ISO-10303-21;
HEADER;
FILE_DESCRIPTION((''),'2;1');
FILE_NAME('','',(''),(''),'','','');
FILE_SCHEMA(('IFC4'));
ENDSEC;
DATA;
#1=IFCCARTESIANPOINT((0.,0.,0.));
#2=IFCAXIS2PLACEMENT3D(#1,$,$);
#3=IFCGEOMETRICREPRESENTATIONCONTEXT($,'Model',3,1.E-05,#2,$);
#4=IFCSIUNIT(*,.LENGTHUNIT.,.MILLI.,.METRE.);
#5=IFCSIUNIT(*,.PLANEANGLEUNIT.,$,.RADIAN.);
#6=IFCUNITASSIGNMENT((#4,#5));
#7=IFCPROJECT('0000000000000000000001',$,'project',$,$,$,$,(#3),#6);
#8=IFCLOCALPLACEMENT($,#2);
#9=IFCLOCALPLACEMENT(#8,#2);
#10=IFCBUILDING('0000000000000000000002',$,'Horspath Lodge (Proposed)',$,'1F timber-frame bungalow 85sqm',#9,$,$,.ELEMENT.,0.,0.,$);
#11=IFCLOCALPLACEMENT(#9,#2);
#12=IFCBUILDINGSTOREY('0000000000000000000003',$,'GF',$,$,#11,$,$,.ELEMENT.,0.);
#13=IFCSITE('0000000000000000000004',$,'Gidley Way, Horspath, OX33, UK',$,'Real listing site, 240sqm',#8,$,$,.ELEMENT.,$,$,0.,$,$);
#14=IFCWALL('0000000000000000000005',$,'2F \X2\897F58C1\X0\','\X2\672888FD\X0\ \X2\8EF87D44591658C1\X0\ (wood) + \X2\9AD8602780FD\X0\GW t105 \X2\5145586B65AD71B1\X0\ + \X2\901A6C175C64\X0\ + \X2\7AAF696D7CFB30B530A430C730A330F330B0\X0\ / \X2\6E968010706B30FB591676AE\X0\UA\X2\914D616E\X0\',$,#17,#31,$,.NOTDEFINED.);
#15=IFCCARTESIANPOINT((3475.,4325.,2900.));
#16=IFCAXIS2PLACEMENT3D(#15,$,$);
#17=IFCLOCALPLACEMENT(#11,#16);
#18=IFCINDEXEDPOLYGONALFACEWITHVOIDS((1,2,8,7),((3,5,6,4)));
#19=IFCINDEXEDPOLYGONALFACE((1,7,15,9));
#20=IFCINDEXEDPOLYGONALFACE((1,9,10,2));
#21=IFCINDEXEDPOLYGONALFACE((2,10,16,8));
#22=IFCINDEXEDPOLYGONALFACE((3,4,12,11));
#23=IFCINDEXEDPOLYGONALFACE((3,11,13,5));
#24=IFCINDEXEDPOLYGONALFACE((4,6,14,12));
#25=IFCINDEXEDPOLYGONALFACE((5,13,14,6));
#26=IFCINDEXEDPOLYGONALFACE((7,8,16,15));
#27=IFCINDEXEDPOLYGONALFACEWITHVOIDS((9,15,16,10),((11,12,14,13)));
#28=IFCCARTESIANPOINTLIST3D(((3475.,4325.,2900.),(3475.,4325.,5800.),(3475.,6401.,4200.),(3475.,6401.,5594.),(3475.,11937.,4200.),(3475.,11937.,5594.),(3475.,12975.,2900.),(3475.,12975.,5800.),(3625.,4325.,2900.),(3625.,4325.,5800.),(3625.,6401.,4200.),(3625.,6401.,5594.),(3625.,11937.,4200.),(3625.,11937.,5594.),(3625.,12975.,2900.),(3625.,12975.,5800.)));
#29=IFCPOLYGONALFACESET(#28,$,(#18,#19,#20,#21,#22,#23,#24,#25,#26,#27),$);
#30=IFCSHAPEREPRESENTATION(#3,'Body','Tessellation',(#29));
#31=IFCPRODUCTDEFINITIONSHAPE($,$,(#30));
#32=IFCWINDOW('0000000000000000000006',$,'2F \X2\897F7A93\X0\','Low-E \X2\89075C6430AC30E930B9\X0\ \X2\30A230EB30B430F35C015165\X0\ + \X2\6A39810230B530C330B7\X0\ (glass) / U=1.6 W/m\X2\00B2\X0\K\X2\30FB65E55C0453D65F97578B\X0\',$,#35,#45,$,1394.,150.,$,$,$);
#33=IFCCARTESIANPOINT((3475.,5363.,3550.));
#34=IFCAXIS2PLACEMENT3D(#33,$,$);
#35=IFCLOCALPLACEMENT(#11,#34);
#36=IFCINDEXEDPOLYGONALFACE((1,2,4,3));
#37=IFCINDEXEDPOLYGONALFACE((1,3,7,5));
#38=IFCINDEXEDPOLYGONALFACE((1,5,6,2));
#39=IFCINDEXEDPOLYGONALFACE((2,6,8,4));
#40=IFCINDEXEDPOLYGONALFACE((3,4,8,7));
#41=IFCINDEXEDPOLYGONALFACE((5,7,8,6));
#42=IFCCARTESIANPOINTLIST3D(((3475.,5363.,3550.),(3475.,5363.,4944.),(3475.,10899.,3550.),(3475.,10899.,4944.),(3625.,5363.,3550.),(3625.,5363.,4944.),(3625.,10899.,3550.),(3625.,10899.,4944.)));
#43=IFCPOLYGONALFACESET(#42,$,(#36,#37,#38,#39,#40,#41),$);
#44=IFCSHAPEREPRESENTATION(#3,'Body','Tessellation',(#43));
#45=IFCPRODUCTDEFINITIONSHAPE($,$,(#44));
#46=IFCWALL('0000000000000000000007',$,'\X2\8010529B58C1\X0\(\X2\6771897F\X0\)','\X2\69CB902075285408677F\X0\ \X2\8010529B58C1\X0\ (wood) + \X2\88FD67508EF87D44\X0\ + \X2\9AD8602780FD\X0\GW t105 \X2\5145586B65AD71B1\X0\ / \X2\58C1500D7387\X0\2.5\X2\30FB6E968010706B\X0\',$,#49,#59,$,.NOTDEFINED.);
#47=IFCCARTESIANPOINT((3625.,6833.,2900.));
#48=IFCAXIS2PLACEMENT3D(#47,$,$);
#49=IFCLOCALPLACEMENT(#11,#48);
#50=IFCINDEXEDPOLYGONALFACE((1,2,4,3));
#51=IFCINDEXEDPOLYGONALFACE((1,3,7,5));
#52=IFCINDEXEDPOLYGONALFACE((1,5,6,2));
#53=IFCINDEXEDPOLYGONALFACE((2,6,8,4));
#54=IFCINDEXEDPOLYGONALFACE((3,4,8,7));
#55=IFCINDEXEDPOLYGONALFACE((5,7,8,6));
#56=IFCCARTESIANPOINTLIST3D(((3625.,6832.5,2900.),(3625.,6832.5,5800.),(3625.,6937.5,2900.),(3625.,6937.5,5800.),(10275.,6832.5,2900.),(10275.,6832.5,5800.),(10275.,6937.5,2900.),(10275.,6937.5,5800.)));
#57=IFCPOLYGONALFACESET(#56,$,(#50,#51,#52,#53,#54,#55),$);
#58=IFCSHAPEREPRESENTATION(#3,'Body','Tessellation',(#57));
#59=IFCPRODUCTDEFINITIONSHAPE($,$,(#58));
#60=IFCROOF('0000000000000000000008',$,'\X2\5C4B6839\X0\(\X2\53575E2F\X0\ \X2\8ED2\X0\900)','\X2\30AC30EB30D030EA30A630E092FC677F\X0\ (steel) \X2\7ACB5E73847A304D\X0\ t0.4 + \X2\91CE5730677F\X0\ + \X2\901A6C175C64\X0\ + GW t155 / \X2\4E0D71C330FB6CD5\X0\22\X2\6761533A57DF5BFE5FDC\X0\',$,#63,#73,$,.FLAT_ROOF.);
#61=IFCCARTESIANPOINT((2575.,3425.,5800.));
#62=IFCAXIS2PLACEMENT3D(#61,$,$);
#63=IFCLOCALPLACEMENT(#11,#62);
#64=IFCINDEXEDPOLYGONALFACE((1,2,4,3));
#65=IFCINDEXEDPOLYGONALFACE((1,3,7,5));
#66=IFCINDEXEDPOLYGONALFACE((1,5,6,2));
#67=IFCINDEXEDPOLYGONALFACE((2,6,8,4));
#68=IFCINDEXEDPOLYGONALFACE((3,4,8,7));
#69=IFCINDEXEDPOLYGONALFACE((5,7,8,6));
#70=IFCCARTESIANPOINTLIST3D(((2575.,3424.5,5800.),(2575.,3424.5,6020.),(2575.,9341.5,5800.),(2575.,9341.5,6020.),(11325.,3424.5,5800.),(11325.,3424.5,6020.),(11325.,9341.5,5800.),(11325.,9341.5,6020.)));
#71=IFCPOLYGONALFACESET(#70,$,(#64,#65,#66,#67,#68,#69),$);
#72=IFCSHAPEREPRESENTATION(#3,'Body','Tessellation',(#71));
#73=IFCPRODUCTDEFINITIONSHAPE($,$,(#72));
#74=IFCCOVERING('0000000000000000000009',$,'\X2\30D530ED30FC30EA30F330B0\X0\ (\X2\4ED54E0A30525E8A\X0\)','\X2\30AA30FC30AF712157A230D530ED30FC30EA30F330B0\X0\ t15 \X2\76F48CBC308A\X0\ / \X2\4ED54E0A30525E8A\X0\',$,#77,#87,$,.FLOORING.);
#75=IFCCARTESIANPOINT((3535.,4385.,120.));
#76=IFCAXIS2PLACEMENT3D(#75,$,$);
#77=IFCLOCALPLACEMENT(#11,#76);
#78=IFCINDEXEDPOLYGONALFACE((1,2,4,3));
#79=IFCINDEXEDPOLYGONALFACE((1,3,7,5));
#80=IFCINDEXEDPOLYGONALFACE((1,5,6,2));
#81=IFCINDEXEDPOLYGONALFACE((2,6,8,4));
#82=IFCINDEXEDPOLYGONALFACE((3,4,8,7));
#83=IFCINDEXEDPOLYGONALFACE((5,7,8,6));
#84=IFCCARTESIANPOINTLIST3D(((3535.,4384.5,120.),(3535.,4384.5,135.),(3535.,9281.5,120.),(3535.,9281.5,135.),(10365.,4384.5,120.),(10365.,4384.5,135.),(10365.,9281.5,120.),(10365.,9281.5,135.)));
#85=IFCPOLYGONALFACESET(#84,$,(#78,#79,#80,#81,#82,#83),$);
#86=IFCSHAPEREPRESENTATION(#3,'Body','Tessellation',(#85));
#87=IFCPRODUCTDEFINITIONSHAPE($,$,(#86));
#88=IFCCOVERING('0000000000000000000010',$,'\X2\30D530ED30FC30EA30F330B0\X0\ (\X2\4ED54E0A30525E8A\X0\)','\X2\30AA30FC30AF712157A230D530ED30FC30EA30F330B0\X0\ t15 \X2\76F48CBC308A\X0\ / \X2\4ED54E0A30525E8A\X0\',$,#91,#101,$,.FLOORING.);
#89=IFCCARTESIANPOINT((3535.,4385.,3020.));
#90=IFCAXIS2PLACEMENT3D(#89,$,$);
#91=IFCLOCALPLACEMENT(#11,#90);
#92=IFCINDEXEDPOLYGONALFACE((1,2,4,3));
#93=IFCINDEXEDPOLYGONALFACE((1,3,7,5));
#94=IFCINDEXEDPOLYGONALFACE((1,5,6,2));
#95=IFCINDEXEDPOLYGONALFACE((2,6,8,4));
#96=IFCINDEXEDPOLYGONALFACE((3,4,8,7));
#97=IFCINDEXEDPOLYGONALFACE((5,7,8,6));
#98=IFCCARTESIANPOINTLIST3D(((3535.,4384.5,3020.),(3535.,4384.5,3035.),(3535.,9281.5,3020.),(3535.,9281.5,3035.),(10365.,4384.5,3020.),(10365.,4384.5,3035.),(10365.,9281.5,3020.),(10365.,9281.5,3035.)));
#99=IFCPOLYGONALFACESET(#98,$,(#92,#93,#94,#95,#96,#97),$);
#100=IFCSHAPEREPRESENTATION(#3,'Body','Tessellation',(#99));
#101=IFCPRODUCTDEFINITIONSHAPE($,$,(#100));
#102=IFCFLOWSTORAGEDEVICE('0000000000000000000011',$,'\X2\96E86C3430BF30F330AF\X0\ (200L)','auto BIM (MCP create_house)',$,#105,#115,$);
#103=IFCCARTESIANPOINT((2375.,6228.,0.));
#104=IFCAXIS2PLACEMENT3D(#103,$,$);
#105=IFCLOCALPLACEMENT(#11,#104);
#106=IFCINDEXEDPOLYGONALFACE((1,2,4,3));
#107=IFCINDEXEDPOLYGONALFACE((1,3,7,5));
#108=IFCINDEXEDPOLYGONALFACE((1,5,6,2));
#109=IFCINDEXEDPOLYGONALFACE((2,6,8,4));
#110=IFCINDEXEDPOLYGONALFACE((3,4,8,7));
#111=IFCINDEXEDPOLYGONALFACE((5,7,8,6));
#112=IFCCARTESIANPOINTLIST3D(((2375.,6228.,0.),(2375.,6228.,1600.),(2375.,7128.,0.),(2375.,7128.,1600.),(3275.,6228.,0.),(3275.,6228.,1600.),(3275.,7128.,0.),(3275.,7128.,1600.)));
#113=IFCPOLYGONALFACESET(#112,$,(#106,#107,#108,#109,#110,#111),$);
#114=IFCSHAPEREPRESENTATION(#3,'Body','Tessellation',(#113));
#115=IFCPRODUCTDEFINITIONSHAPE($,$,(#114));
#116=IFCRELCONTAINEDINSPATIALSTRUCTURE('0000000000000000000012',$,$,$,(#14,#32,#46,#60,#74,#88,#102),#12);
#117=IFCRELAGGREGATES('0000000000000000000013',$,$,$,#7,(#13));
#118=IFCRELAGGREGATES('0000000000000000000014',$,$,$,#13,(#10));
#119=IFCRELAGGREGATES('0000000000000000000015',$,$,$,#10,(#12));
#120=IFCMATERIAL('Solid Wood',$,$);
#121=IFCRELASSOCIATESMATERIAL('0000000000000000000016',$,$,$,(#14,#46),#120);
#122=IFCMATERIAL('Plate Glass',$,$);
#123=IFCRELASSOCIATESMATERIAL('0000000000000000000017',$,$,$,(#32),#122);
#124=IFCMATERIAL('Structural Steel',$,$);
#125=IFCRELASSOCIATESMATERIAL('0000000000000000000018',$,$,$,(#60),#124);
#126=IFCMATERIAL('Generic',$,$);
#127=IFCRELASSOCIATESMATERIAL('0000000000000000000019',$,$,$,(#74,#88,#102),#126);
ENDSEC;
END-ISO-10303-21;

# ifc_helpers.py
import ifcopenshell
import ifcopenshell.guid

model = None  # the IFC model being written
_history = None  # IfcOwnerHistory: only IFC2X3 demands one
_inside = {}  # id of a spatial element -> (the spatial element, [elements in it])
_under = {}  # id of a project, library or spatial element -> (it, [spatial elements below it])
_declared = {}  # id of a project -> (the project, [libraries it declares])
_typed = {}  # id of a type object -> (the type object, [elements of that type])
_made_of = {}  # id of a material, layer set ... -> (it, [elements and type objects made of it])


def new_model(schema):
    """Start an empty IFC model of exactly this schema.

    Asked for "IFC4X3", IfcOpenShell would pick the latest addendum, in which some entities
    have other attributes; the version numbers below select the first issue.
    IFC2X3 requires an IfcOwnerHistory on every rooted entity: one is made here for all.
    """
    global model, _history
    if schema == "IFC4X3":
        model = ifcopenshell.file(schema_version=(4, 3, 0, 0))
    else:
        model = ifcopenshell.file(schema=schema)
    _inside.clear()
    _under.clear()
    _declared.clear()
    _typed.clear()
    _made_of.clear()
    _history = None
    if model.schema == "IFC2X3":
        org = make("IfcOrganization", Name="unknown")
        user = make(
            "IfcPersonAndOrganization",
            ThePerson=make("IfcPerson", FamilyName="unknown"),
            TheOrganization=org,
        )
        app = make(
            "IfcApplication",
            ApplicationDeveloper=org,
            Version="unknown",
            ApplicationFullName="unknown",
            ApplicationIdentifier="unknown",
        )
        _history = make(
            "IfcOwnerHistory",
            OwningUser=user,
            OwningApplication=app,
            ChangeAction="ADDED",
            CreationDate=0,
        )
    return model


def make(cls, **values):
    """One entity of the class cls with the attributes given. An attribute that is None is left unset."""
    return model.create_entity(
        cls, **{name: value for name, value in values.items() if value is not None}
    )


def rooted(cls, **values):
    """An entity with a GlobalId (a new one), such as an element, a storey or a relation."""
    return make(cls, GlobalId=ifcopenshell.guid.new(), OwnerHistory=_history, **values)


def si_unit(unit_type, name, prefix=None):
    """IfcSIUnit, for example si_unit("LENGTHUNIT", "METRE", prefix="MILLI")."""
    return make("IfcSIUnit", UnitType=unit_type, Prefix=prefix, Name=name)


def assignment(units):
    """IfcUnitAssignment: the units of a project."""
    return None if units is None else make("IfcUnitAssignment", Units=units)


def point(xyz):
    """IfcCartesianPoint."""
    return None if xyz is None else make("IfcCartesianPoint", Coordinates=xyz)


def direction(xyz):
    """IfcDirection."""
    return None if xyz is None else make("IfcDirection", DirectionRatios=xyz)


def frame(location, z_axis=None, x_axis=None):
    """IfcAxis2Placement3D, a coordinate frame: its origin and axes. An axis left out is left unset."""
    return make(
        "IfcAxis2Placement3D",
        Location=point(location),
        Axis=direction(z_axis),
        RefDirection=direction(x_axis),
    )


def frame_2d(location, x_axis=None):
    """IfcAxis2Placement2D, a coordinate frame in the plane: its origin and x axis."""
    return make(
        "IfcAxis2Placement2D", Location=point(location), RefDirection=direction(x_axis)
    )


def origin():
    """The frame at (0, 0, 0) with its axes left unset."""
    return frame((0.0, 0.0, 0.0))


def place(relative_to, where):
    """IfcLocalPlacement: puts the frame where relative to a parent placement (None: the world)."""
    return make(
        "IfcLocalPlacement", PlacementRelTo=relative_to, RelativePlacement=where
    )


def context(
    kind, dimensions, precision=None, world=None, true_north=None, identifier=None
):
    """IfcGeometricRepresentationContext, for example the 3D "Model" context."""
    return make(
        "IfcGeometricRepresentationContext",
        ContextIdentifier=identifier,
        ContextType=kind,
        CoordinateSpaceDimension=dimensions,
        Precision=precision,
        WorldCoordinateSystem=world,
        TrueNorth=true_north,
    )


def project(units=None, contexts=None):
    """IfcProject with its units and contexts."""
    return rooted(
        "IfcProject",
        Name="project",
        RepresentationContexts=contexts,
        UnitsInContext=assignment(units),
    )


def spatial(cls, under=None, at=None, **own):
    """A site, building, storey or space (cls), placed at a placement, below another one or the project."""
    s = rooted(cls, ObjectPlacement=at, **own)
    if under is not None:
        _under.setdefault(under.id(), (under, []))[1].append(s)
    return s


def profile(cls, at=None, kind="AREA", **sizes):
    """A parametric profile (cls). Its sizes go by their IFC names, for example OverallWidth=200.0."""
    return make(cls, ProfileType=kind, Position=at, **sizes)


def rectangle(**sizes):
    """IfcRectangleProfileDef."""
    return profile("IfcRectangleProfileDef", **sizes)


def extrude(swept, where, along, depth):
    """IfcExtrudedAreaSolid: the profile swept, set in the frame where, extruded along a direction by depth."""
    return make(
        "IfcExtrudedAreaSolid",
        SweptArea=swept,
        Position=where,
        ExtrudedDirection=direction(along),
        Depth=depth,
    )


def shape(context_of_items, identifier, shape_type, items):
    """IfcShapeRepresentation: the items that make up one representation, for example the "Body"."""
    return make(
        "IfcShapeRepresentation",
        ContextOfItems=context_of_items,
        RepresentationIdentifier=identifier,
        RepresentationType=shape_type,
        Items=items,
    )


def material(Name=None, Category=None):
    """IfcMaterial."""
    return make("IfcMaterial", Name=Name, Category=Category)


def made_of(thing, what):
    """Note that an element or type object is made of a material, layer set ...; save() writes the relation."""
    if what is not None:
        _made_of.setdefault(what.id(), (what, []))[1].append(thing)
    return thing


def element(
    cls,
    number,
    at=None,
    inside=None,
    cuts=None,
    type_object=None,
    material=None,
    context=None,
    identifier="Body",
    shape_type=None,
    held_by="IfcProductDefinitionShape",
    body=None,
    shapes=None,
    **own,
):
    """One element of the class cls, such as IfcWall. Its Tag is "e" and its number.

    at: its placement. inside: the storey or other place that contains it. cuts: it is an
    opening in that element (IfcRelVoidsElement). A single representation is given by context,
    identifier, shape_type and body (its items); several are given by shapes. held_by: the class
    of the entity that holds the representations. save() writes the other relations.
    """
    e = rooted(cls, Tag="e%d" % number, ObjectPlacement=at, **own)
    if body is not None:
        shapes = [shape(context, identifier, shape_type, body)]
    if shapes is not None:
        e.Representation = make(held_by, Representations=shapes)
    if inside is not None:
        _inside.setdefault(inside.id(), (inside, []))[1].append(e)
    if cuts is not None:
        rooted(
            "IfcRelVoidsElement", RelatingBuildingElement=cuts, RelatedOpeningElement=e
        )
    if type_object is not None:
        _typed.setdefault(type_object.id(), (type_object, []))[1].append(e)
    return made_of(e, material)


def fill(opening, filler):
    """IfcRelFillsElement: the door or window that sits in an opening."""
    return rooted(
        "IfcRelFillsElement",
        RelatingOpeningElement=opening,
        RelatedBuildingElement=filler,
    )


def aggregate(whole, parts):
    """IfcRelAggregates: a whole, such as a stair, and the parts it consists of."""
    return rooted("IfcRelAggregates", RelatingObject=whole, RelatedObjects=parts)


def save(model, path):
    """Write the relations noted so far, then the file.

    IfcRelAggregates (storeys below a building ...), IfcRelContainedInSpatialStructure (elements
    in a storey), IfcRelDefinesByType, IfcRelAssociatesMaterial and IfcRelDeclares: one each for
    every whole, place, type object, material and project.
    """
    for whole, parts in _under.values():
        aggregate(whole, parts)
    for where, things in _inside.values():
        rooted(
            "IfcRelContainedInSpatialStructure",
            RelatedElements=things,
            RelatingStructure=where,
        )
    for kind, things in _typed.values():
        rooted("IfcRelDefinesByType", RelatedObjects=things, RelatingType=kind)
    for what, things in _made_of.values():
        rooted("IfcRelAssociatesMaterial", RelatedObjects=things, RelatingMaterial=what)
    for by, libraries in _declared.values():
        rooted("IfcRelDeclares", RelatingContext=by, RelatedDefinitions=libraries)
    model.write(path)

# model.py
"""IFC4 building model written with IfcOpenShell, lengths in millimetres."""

from ifc_helpers import new_model, si_unit, frame, frame_2d, origin, place, context, project, spatial, rectangle, extrude, material, element, fill, save


model = new_model("IFC4")

# Units and contexts
model_context = context("Model", 3, precision=1e-05, world=origin())
ifc_project = project(units=[si_unit("LENGTHUNIT", "METRE", prefix="MILLI"), si_unit("PLANEANGLEUNIT", "RADIAN")], contexts=[model_context])

# Site, building, storey
site_placement = place(None, origin())
site = spatial("IfcSite", under=ifc_project, at=site_placement, Name="Gidley Way, Horspath, OX33, UK", ObjectType="Real listing site, 240sqm", CompositionType="ELEMENT", RefElevation=0.0)
building_placement = place(site_placement, origin())
building = spatial("IfcBuilding", under=site, at=building_placement, Name="Horspath Lodge (Proposed)", ObjectType="1F timber-frame bungalow 85sqm", CompositionType="ELEMENT", ElevationOfRefHeight=0.0, ElevationOfTerrain=0.0)
storey_placement = place(building_placement, origin())
storey = spatial("IfcBuildingStorey", under=building, at=storey_placement, Name="GF", CompositionType="ELEMENT", Elevation=0.0)

# Shared definitions
ifc_material_1 = material(Name="Solid Wood")
ifc_material_2 = material(Name="Generic")

# Shared definitions
ifc_material_3 = material(Name="Plate Glass")

# Wall, opening, window
wall_1_placement = place(storey_placement, frame((3475.0, 4325.0, 2900.0)))
wall_1 = element("IfcWall", 1, at=wall_1_placement, inside=storey, material=ifc_material_1, Name="2F 西壁", Description="木製 軸組外壁 (wood) + 高性能GW t105 充填断熱 + 通気層 + 窯業系サイディング / 準耐火・外皮UA配慮", PredefinedType="NOTDEFINED", context=model_context, shape_type="SweptSolid", body=[
    extrude(rectangle(XDim=150.0, YDim=8650.0, at=frame_2d((75.0, 4325.0))), frame((3475.0, 4325.0, 2900.0)), (0.0, 0.0, 1.0), 2900.0),
])
opening_1_placement = place(storey_placement, frame((3475.0, 5363.0, 3550.0)))
opening_1 = element("IfcOpeningElement", 2, at=opening_1_placement, cuts=wall_1, PredefinedType="NOTDEFINED", context=model_context, shape_type="SweptSolid", body=[
    extrude(rectangle(XDim=150.0, YDim=5536.0, at=frame_2d((75.0, 2768.0))), frame((3475.0, 5363.0, 3550.0)), (0.0, 0.0, 1.0), 1394.0),
])
window_1_placement = place(storey_placement, frame((3475.0, 5363.0, 3550.0)))
window_1 = element("IfcWindow", 3, at=window_1_placement, inside=storey, material=ifc_material_3, Name="2F 西窓", Description="Low-E 複層ガラス アルゴン封入 + 樹脂サッシ (glass) / U=1.6 W/m²K・日射取得型", OverallHeight=1394.0, OverallWidth=150.0, context=model_context, shape_type="SweptSolid", body=[
    extrude(rectangle(XDim=150.0, YDim=5536.0, at=frame_2d((75.0, 2768.0))), frame((3475.0, 5363.0, 3550.0)), (0.0, 0.0, 1.0), 1394.0),
])
fill(opening_1, window_1)

# Wall
wall_2_placement = place(storey_placement, frame((3625.0, 6833.0, 2900.0)))
element("IfcWall", 4, at=wall_2_placement, inside=storey, material=ifc_material_1, Name="耐力壁(東西)", Description="構造用合板 耐力壁 (wood) + 製材軸組 + 高性能GW t105 充填断熱 / 壁倍率2.5・準耐火", PredefinedType="NOTDEFINED", context=model_context, shape_type="SweptSolid", body=[
    extrude(rectangle(XDim=6650.0, YDim=105.0, at=frame_2d((3325.0, 52.0))), frame((3625.0, 6833.0, 2900.0)), (0.0, 0.0, 1.0), 2900.0),
])

# Roof
ifc_material_4 = material(Name="Structural Steel")
for number, where, name in (
    (5, (2575.0, 3425.0, 5800.0), "屋根(南帯 軒900)"),
):
    element("IfcRoof", number, at=place(storey_placement, frame(where)), inside=storey, material=ifc_material_4, Name=name, Description="ガルバリウム鋼板 (steel) 立平葺き t0.4 + 野地板 + 通気層 + GW t155 / 不燃・法22条区域対応", PredefinedType="FLAT_ROOF", context=model_context, shape_type="SweptSolid", body=[
        extrude(rectangle(XDim=8750.0, YDim=5917.0, at=frame_2d((4375.0, 2958.0))), frame((2575.0, 3425.0, 5800.0)), (0.0, 0.0, 1.0), 220.0),
    ])

# Coverings
covering_1_placement = place(storey_placement, frame((3535.0, 4385.0, 120.0)))
element("IfcCovering", 6, at=covering_1_placement, inside=storey, material=ifc_material_2, Name="フローリング (仕上げ床)", Description="オーク無垢フローリング t15 直貼り / 仕上げ床", PredefinedType="FLOORING", context=model_context, shape_type="SweptSolid", body=[
    extrude(rectangle(XDim=6830.0, YDim=4897.0, at=frame_2d((3415.0, 2448.0))), frame((3535.0, 4385.0, 120.0)), (0.0, 0.0, 1.0), 15.0),
])
covering_2_placement = place(storey_placement, frame((3535.0, 4385.0, 3020.0)))
element("IfcCovering", 7, at=covering_2_placement, inside=storey, material=ifc_material_2, Name="フローリング (仕上げ床)", Description="オーク無垢フローリング t15 直貼り / 仕上げ床", PredefinedType="FLOORING", context=model_context, shape_type="SweptSolid", body=[
    extrude(rectangle(XDim=6830.0, YDim=4897.0, at=frame_2d((3415.0, 2448.0))), frame((3535.0, 4385.0, 3020.0)), (0.0, 0.0, 1.0), 15.0),
])

# Flow storage device
flow_storage_device_placement = place(storey_placement, frame((2375.0, 6228.0, 0.0)))
element("IfcFlowStorageDevice", 8, at=flow_storage_device_placement, inside=storey, material=ifc_material_2, Name="雨水タンク (200L)", Description="auto BIM (MCP create_house)", context=model_context, shape_type="SweptSolid", body=[
    extrude(rectangle(XDim=900.0, YDim=900.0, at=frame_2d((450.0, 450.0))), frame((2375.0, 6228.0, 0.0)), (0.0, 0.0, 1.0), 1600.0),
])

save(model, "model.ifc")
